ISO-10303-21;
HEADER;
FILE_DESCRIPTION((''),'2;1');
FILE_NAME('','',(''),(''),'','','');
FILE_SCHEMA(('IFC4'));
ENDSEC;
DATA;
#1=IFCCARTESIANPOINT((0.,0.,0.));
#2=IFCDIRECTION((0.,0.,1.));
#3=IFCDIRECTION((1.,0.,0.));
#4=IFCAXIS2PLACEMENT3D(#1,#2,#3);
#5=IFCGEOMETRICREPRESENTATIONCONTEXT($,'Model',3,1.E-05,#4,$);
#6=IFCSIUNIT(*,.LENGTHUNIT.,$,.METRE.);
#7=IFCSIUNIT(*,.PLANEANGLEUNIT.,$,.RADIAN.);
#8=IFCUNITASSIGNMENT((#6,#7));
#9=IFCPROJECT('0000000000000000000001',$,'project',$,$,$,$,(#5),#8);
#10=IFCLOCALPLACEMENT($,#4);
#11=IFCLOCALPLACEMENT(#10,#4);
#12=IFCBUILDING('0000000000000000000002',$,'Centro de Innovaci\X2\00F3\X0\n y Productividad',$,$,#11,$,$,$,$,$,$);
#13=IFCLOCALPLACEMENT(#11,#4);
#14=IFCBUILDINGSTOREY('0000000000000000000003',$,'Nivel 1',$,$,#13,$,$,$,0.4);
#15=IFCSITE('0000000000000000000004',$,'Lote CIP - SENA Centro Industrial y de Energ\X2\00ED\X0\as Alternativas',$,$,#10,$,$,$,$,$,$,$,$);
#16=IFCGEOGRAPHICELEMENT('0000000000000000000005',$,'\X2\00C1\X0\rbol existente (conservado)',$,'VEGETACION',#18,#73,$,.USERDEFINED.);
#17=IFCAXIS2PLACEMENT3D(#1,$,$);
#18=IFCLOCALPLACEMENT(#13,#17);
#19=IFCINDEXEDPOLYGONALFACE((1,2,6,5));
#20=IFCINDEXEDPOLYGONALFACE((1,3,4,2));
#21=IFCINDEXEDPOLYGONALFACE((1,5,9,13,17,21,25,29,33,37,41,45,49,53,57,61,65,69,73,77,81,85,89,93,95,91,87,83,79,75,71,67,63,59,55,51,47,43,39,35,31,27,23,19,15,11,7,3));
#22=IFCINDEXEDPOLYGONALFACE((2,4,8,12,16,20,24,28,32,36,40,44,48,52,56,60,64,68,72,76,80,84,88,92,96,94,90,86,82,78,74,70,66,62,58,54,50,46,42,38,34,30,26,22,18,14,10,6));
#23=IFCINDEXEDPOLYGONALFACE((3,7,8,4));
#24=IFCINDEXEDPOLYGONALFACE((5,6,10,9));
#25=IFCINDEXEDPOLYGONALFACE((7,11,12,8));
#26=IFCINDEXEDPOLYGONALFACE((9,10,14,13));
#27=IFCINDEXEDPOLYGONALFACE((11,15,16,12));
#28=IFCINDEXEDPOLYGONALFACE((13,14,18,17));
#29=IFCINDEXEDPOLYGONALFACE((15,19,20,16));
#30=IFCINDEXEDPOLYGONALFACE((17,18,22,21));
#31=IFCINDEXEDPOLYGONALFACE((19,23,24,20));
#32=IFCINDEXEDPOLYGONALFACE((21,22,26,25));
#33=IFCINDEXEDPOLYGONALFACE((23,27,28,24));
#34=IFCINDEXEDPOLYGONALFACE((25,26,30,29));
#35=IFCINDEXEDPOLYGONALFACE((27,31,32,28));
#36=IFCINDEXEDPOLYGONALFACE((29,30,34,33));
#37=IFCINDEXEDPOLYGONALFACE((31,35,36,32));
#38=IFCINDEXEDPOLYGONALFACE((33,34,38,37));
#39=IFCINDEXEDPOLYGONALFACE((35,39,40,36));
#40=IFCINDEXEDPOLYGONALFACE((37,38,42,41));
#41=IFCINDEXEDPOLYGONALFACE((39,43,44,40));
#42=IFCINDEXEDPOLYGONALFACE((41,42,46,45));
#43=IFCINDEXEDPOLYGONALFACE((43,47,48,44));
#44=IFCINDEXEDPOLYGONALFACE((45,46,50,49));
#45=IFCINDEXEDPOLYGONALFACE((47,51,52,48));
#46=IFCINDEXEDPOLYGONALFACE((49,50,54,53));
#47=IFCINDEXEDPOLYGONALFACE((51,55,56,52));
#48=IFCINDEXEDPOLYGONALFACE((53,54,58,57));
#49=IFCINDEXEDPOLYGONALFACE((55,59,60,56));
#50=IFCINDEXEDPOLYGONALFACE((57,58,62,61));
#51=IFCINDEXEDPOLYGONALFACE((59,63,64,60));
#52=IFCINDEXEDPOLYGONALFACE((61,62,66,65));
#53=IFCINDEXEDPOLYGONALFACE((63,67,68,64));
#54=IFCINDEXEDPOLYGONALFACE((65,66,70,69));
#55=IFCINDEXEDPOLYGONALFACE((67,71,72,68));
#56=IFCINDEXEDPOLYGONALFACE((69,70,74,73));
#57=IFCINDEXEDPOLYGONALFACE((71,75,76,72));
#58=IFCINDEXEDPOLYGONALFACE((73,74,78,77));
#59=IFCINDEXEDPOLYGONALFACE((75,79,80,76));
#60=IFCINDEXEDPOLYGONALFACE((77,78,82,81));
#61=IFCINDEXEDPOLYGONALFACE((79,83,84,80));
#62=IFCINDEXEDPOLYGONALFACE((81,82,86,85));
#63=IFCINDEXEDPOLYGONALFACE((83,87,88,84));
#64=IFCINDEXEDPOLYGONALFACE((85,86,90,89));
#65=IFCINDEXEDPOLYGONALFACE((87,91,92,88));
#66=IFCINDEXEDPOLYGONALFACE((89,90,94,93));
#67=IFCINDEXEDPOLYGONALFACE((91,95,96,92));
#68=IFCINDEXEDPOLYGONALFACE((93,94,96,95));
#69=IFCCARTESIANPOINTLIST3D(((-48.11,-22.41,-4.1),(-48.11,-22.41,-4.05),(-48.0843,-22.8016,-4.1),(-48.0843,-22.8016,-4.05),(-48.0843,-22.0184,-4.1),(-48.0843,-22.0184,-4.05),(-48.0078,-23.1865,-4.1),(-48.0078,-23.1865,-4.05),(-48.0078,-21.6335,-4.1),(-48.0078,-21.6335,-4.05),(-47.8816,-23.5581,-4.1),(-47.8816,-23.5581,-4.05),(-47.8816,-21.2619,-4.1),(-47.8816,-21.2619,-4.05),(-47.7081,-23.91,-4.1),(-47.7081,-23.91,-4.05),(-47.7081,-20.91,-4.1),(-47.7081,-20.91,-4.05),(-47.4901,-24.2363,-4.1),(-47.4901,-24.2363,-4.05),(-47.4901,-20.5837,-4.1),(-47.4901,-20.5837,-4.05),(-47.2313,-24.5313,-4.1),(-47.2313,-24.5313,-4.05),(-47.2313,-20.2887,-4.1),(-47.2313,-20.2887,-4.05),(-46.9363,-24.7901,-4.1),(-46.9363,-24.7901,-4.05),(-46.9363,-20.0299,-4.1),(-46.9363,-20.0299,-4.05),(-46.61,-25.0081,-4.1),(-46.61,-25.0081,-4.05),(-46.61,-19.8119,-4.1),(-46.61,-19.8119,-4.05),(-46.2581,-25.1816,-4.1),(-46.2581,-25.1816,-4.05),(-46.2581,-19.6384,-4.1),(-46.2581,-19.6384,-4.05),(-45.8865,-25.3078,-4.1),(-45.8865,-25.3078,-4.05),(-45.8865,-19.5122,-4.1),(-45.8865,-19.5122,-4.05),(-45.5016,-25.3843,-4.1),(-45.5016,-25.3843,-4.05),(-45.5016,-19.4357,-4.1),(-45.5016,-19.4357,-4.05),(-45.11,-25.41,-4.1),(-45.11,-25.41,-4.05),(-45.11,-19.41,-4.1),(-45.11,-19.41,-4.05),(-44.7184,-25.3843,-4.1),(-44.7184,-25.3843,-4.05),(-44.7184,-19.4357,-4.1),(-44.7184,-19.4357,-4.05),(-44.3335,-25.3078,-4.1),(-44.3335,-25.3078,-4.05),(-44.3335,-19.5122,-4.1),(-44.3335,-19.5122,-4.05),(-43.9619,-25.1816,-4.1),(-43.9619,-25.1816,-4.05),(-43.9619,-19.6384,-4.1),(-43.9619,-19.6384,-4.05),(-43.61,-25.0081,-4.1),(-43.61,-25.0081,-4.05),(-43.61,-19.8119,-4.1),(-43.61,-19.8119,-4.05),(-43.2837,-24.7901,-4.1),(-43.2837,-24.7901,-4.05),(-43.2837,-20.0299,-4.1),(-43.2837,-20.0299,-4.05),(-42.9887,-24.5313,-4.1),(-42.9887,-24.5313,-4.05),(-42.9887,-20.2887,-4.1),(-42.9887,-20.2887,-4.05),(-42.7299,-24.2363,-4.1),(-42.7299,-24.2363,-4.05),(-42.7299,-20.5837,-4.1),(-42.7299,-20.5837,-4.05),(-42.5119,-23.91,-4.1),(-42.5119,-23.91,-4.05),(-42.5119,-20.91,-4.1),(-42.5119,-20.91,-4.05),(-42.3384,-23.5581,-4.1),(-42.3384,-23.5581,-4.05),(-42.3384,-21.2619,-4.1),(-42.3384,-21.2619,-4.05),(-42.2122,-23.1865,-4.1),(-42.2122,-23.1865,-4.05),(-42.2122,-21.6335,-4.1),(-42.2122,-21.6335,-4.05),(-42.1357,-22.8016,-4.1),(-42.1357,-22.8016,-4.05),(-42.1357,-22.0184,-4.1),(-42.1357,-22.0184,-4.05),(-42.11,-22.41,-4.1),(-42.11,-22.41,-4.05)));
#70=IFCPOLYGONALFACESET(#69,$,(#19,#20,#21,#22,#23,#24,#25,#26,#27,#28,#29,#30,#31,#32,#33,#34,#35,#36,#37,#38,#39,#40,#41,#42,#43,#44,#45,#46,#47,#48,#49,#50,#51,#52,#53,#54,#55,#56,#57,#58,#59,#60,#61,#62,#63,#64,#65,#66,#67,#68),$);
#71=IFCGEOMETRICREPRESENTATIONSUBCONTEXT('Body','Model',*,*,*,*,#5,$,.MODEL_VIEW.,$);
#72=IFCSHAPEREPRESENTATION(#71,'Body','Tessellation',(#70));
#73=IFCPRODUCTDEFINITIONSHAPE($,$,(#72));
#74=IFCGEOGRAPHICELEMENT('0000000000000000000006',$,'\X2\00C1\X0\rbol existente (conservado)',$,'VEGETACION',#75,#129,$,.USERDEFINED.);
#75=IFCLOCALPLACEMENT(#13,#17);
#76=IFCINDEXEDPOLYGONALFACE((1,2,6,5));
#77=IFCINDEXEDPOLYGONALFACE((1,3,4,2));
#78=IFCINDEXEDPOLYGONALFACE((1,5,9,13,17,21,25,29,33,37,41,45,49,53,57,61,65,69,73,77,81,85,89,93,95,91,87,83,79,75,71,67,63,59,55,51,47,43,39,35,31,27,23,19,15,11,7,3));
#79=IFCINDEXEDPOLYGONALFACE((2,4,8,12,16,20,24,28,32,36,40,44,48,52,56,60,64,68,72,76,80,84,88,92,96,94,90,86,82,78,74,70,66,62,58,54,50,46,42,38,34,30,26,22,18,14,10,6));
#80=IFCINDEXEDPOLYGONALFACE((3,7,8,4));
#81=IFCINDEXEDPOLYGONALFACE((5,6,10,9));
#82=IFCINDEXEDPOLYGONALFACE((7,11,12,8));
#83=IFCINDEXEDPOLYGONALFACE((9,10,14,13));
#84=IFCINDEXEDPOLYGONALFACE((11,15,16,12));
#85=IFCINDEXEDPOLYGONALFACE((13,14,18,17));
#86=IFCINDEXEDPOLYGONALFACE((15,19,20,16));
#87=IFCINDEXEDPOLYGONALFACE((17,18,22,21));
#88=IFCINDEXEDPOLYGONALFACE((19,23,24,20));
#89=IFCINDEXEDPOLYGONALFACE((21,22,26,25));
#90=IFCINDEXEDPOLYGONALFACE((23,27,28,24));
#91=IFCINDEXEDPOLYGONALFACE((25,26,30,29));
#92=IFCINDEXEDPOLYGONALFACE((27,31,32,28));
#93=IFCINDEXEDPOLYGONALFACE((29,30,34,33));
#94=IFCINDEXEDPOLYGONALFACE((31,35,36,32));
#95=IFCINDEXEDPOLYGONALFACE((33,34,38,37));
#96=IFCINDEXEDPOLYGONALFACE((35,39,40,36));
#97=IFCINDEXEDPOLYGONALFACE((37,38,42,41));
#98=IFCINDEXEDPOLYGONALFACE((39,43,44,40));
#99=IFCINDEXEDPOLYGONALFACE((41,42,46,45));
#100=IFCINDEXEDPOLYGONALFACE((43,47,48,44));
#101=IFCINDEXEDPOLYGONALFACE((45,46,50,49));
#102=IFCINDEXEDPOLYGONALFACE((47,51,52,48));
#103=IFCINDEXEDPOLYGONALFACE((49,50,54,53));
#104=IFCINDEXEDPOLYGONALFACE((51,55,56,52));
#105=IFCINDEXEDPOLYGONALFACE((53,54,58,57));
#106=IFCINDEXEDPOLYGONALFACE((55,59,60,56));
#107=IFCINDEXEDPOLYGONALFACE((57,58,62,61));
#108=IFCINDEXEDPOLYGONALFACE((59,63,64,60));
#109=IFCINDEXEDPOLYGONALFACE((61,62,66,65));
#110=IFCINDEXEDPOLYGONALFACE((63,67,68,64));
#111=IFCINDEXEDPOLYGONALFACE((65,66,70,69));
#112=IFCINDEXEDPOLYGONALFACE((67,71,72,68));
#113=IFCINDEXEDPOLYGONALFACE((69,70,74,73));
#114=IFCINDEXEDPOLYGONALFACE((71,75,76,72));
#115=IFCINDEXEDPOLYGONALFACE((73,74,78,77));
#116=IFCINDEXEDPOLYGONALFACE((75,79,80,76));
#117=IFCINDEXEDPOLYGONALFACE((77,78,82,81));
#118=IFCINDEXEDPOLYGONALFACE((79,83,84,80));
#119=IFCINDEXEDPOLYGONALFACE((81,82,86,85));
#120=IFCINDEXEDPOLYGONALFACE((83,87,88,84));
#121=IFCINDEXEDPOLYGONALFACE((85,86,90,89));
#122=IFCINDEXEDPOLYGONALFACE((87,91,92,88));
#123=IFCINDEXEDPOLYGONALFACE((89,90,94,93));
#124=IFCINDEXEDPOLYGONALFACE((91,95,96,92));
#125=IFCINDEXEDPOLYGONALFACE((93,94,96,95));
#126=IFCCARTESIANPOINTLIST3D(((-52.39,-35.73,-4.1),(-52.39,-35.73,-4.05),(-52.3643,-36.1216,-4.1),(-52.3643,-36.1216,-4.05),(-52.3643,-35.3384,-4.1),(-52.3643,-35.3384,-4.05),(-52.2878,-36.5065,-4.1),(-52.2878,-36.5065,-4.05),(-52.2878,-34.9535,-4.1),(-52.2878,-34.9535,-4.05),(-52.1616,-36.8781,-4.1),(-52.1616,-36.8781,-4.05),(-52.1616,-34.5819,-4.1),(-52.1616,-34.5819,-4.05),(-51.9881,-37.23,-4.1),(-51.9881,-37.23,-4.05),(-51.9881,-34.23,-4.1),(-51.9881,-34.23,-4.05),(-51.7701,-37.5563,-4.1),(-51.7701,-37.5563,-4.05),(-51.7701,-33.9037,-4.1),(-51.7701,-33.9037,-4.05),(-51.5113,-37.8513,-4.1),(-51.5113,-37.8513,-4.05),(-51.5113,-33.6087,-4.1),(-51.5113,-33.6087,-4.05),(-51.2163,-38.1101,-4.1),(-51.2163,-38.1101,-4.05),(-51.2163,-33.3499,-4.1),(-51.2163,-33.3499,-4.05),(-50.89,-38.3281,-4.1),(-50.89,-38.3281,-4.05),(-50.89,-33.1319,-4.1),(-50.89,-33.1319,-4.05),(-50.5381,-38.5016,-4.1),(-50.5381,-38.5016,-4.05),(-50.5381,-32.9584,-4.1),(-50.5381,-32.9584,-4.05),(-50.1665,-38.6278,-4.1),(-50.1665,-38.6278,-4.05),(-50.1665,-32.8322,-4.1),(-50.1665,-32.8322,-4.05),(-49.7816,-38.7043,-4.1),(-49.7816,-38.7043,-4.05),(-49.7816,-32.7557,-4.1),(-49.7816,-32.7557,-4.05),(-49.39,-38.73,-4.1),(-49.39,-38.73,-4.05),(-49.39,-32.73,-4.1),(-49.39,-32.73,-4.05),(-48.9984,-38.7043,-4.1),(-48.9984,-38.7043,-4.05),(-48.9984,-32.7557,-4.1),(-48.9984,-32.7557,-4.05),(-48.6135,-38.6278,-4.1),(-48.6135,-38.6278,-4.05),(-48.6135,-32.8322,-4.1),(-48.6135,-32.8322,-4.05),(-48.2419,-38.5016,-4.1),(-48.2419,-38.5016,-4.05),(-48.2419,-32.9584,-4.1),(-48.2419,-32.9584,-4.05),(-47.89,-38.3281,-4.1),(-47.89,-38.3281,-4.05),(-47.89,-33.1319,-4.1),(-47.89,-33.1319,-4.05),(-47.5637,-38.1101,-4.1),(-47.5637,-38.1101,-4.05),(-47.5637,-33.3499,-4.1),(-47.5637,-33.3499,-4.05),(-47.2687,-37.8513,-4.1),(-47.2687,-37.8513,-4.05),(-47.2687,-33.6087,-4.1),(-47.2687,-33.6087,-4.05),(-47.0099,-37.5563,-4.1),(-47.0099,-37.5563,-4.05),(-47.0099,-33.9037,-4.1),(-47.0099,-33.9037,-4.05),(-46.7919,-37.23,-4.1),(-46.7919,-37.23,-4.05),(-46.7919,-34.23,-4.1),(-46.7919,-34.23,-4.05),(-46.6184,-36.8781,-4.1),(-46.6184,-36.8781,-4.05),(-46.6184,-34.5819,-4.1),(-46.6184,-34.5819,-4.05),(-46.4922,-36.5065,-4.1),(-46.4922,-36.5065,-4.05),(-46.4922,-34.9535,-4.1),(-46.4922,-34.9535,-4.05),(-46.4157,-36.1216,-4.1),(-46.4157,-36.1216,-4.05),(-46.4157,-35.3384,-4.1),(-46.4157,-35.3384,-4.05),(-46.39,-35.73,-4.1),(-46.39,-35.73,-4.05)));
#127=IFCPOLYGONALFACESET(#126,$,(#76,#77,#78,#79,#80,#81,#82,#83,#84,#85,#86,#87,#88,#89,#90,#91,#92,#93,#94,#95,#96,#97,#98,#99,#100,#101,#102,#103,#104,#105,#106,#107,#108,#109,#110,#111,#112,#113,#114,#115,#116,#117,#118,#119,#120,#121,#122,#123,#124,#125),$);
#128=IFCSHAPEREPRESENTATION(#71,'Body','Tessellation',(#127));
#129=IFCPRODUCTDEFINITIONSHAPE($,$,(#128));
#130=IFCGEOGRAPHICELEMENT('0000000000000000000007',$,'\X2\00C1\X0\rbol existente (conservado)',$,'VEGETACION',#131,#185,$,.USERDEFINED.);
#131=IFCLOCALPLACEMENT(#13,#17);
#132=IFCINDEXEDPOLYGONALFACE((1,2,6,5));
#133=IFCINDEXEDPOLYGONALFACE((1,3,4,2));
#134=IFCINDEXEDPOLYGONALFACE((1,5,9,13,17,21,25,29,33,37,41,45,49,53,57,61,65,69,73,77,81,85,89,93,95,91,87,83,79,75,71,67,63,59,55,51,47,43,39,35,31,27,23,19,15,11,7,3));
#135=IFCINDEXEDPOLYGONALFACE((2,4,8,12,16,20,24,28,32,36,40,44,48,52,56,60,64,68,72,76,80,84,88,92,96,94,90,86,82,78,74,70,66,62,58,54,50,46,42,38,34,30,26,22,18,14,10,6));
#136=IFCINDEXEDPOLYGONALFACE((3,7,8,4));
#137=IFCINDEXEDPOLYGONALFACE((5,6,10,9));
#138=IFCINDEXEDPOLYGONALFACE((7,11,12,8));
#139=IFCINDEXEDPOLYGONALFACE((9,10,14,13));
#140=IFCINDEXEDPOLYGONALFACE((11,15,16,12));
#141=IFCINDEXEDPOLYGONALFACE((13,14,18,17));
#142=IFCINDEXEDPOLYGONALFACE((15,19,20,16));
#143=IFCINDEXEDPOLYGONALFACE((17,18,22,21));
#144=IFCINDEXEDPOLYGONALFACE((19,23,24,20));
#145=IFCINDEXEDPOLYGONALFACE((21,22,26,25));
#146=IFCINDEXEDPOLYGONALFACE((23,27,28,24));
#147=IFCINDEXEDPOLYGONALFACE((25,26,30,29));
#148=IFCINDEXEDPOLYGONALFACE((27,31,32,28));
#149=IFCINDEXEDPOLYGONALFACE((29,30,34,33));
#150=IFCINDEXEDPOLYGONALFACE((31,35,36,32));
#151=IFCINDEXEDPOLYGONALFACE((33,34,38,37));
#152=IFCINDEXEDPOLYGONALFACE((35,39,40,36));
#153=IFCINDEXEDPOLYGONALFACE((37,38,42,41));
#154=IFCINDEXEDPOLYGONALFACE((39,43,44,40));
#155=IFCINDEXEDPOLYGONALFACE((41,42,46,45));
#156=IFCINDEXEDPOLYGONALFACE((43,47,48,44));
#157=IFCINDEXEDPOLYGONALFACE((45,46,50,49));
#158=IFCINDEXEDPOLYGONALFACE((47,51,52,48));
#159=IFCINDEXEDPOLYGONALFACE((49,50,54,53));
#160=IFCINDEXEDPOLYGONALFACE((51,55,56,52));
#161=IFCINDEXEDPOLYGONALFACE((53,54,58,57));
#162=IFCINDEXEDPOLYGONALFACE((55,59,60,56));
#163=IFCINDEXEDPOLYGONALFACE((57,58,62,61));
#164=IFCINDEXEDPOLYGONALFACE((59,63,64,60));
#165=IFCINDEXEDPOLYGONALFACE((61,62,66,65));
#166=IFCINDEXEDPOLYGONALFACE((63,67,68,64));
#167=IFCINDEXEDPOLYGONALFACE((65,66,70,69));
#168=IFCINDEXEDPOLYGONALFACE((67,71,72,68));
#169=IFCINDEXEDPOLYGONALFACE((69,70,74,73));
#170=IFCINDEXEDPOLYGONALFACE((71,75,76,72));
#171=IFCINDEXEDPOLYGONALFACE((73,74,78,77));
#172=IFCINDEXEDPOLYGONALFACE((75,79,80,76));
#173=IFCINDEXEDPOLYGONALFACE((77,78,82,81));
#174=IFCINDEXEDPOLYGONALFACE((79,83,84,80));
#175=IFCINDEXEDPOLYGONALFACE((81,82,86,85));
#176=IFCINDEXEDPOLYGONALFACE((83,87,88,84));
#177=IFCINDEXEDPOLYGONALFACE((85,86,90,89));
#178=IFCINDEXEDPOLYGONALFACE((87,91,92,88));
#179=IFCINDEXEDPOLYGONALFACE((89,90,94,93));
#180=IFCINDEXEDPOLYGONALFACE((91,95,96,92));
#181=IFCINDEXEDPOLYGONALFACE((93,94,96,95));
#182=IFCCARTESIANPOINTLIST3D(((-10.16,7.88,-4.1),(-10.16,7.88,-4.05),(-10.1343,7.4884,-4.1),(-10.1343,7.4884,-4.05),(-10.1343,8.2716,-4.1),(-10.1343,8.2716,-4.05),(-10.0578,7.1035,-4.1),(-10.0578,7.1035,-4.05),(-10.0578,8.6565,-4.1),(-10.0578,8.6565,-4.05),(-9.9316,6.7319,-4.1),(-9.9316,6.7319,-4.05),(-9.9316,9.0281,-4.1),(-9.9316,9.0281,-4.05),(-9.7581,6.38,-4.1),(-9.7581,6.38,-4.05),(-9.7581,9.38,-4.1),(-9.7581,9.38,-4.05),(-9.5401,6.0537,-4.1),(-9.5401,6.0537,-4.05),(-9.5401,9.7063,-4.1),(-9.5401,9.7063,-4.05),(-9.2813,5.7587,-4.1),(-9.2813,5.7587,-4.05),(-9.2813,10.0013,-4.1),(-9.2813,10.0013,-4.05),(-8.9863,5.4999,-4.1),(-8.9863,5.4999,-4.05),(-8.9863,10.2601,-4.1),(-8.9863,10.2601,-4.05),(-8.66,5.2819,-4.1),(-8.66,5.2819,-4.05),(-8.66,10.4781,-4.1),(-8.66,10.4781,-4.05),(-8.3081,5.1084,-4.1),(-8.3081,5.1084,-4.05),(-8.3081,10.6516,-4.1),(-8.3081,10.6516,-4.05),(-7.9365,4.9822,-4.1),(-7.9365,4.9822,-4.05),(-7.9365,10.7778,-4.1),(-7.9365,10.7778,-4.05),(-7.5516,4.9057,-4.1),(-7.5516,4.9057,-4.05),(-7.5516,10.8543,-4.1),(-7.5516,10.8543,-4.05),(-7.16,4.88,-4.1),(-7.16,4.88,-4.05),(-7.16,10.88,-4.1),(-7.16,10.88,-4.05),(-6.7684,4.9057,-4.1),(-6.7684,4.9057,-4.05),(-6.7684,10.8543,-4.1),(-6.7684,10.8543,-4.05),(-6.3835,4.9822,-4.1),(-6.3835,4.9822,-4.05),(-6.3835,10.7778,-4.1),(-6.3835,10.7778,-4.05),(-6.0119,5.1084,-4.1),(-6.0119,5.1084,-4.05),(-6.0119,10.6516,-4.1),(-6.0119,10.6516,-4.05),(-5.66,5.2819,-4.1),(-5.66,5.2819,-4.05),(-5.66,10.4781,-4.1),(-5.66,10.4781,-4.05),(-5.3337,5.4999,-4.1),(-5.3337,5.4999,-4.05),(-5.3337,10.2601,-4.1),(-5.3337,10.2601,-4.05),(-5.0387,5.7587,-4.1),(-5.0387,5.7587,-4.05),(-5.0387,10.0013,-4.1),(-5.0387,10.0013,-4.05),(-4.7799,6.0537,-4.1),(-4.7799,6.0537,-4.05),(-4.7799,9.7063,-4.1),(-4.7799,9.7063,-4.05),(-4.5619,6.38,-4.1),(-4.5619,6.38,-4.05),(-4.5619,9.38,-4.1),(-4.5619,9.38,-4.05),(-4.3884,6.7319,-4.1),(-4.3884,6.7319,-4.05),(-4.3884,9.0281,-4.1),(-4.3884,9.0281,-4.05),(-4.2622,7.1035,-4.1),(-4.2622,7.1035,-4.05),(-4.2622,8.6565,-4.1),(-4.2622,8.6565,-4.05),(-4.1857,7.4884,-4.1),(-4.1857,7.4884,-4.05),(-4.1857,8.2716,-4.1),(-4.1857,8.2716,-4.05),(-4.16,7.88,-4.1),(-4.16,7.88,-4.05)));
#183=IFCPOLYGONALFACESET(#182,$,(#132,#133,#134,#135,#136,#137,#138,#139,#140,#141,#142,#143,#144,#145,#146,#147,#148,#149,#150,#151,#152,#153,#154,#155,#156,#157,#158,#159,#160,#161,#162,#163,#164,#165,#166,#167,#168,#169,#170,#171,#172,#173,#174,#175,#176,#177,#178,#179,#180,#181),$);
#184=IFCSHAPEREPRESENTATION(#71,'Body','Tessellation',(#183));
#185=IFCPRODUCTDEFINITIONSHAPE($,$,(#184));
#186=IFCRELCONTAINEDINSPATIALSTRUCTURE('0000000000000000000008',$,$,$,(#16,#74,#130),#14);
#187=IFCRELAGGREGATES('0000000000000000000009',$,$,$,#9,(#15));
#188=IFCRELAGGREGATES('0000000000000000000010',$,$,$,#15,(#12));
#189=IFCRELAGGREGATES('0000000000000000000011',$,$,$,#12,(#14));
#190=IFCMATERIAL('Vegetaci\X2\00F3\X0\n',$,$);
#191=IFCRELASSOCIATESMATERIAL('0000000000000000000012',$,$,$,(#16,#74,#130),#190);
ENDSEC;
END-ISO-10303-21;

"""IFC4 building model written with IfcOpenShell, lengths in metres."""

from ifc_helpers import new_model, si_unit, frame, origin_with_axes, place, context, subcontext, project, spatial, polyline, outline, extrude, material, element, save


model = new_model("IFC4")

# Units and contexts
model_context = context("Model", 3, precision=1e-05, world=origin_with_axes())
body_context = subcontext(model_context, "Body", "Model", "MODEL_VIEW")
ifc_project = project(units=[si_unit("LENGTHUNIT", "METRE"), si_unit("PLANEANGLEUNIT", "RADIAN")], contexts=[model_context])

# Site, building, storey
site_placement = place(None, origin_with_axes())
site = spatial("IfcSite", under=ifc_project, at=site_placement, Name="Lote CIP - SENA Centro Industrial y de Energías Alternativas")
building_placement = place(site_placement, origin_with_axes())
building = spatial("IfcBuilding", under=site, at=building_placement, Name="Centro de Innovación y Productividad")
storey_placement = place(building_placement, origin_with_axes())
storey = spatial("IfcBuildingStorey", under=building, at=storey_placement, Name="Nivel 1", Elevation=0.4)

# Geographic elements
ifc_material_1 = material(Name="Vegetación")
geographic_element_1_placement = place(storey_placement, origin_with_axes())
element("IfcGeographicElement", 1, at=geographic_element_1_placement, inside=storey, material=ifc_material_1, Name="Árbol existente (conservado)", ObjectType="VEGETACION", PredefinedType="USERDEFINED", context=body_context, shape_type="SweptSolid", body=[
    extrude(outline(polyline([(-42.11, -22.41), (-42.1357, -22.8016), (-42.2122, -23.1865), (-42.3384, -23.5581), (-42.5119, -23.91), (-42.7299, -24.2363), (-42.9887, -24.5313), (-43.2837, -24.7901), (-43.61, -25.0081), (-43.9619, -25.1816), (-44.3335, -25.3078), (-44.7184, -25.3843), (-45.11, -25.41), (-45.5016, -25.3843), (-45.8865, -25.3078), (-46.2581, -25.1816), (-46.61, -25.0081), (-46.9363, -24.7901), (-47.2313, -24.5313), (-47.4901, -24.2363), (-47.7081, -23.91), (-47.8816, -23.5581), (-48.0078, -23.1865), (-48.0843, -22.8016), (-48.11, -22.41), (-48.0843, -22.0184), (-48.0078, -21.6335), (-47.8816, -21.2619), (-47.7081, -20.91), (-47.4901, -20.5837), (-47.2313, -20.2887), (-46.9363, -20.0299), (-46.61, -19.8119), (-46.2581, -19.6384), (-45.8865, -19.5122), (-45.5016, -19.4357), (-45.11, -19.41), (-44.7184, -19.4357), (-44.3335, -19.5122), (-43.9619, -19.6384), (-43.61, -19.8119), (-43.2837, -20.0299), (-42.9887, -20.2887), (-42.7299, -20.5837), (-42.5119, -20.91), (-42.3384, -21.2619), (-42.2122, -21.6335), (-42.1357, -22.0184), (-42.11, -22.41)])), frame((0.0, 0.0, -4.1)), (0.0, 0.0, 1.0), 0.05),
])
geographic_element_2_placement = place(storey_placement, origin_with_axes())
element("IfcGeographicElement", 2, at=geographic_element_2_placement, inside=storey, material=ifc_material_1, Name="Árbol existente (conservado)", ObjectType="VEGETACION", PredefinedType="USERDEFINED", context=body_context, shape_type="SweptSolid", body=[
    extrude(outline(polyline([(-46.39, -35.73), (-46.4157, -36.1216), (-46.4922, -36.5065), (-46.6184, -36.8781), (-46.7919, -37.23), (-47.0099, -37.5563), (-47.2687, -37.8513), (-47.5637, -38.1101), (-47.89, -38.3281), (-48.2419, -38.5016), (-48.6135, -38.6278), (-48.9984, -38.7043), (-49.39, -38.73), (-49.7816, -38.7043), (-50.1665, -38.6278), (-50.5381, -38.5016), (-50.89, -38.3281), (-51.2163, -38.1101), (-51.5113, -37.8513), (-51.7701, -37.5563), (-51.9881, -37.23), (-52.1616, -36.8781), (-52.2878, -36.5065), (-52.3643, -36.1216), (-52.39, -35.73), (-52.3643, -35.3384), (-52.2878, -34.9535), (-52.1616, -34.5819), (-51.9881, -34.23), (-51.7701, -33.9037), (-51.5113, -33.6087), (-51.2163, -33.3499), (-50.89, -33.1319), (-50.5381, -32.9584), (-50.1665, -32.8322), (-49.7816, -32.7557), (-49.39, -32.73), (-48.9984, -32.7557), (-48.6135, -32.8322), (-48.2419, -32.9584), (-47.89, -33.1319), (-47.5637, -33.3499), (-47.2687, -33.6087), (-47.0099, -33.9037), (-46.7919, -34.23), (-46.6184, -34.5819), (-46.4922, -34.9535), (-46.4157, -35.3384), (-46.39, -35.73)])), frame((0.0, 0.0, -4.1)), (0.0, 0.0, 1.0), 0.05),
])
geographic_element_3_placement = place(storey_placement, origin_with_axes())
element("IfcGeographicElement", 3, at=geographic_element_3_placement, inside=storey, material=ifc_material_1, Name="Árbol existente (conservado)", ObjectType="VEGETACION", PredefinedType="USERDEFINED", context=body_context, shape_type="SweptSolid", body=[
    extrude(outline(polyline([(-4.16, 7.88), (-4.1857, 7.4884), (-4.2622, 7.1035), (-4.3884, 6.7319), (-4.5619, 6.38), (-4.7799, 6.0537), (-5.0387, 5.7587), (-5.3337, 5.4999), (-5.66, 5.2819), (-6.0119, 5.1084), (-6.3835, 4.9822), (-6.7684, 4.9057), (-7.16, 4.88), (-7.5516, 4.9057), (-7.9365, 4.9822), (-8.3081, 5.1084), (-8.66, 5.2819), (-8.9863, 5.4999), (-9.2813, 5.7587), (-9.5401, 6.0537), (-9.7581, 6.38), (-9.9316, 6.7319), (-10.0578, 7.1035), (-10.1343, 7.4884), (-10.16, 7.88), (-10.1343, 8.2716), (-10.0578, 8.6565), (-9.9316, 9.0281), (-9.7581, 9.38), (-9.5401, 9.7063), (-9.2813, 10.0013), (-8.9863, 10.2601), (-8.66, 10.4781), (-8.3081, 10.6516), (-7.9365, 10.7778), (-7.5516, 10.8543), (-7.16, 10.88), (-6.7684, 10.8543), (-6.3835, 10.7778), (-6.0119, 10.6516), (-5.66, 10.4781), (-5.3337, 10.2601), (-5.0387, 10.0013), (-4.7799, 9.7063), (-4.5619, 9.38), (-4.3884, 9.0281), (-4.2622, 8.6565), (-4.1857, 8.2716), (-4.16, 7.88)])), frame((0.0, 0.0, -4.1)), (0.0, 0.0, 1.0), 0.05),
])

save(model, "model.ifc")
